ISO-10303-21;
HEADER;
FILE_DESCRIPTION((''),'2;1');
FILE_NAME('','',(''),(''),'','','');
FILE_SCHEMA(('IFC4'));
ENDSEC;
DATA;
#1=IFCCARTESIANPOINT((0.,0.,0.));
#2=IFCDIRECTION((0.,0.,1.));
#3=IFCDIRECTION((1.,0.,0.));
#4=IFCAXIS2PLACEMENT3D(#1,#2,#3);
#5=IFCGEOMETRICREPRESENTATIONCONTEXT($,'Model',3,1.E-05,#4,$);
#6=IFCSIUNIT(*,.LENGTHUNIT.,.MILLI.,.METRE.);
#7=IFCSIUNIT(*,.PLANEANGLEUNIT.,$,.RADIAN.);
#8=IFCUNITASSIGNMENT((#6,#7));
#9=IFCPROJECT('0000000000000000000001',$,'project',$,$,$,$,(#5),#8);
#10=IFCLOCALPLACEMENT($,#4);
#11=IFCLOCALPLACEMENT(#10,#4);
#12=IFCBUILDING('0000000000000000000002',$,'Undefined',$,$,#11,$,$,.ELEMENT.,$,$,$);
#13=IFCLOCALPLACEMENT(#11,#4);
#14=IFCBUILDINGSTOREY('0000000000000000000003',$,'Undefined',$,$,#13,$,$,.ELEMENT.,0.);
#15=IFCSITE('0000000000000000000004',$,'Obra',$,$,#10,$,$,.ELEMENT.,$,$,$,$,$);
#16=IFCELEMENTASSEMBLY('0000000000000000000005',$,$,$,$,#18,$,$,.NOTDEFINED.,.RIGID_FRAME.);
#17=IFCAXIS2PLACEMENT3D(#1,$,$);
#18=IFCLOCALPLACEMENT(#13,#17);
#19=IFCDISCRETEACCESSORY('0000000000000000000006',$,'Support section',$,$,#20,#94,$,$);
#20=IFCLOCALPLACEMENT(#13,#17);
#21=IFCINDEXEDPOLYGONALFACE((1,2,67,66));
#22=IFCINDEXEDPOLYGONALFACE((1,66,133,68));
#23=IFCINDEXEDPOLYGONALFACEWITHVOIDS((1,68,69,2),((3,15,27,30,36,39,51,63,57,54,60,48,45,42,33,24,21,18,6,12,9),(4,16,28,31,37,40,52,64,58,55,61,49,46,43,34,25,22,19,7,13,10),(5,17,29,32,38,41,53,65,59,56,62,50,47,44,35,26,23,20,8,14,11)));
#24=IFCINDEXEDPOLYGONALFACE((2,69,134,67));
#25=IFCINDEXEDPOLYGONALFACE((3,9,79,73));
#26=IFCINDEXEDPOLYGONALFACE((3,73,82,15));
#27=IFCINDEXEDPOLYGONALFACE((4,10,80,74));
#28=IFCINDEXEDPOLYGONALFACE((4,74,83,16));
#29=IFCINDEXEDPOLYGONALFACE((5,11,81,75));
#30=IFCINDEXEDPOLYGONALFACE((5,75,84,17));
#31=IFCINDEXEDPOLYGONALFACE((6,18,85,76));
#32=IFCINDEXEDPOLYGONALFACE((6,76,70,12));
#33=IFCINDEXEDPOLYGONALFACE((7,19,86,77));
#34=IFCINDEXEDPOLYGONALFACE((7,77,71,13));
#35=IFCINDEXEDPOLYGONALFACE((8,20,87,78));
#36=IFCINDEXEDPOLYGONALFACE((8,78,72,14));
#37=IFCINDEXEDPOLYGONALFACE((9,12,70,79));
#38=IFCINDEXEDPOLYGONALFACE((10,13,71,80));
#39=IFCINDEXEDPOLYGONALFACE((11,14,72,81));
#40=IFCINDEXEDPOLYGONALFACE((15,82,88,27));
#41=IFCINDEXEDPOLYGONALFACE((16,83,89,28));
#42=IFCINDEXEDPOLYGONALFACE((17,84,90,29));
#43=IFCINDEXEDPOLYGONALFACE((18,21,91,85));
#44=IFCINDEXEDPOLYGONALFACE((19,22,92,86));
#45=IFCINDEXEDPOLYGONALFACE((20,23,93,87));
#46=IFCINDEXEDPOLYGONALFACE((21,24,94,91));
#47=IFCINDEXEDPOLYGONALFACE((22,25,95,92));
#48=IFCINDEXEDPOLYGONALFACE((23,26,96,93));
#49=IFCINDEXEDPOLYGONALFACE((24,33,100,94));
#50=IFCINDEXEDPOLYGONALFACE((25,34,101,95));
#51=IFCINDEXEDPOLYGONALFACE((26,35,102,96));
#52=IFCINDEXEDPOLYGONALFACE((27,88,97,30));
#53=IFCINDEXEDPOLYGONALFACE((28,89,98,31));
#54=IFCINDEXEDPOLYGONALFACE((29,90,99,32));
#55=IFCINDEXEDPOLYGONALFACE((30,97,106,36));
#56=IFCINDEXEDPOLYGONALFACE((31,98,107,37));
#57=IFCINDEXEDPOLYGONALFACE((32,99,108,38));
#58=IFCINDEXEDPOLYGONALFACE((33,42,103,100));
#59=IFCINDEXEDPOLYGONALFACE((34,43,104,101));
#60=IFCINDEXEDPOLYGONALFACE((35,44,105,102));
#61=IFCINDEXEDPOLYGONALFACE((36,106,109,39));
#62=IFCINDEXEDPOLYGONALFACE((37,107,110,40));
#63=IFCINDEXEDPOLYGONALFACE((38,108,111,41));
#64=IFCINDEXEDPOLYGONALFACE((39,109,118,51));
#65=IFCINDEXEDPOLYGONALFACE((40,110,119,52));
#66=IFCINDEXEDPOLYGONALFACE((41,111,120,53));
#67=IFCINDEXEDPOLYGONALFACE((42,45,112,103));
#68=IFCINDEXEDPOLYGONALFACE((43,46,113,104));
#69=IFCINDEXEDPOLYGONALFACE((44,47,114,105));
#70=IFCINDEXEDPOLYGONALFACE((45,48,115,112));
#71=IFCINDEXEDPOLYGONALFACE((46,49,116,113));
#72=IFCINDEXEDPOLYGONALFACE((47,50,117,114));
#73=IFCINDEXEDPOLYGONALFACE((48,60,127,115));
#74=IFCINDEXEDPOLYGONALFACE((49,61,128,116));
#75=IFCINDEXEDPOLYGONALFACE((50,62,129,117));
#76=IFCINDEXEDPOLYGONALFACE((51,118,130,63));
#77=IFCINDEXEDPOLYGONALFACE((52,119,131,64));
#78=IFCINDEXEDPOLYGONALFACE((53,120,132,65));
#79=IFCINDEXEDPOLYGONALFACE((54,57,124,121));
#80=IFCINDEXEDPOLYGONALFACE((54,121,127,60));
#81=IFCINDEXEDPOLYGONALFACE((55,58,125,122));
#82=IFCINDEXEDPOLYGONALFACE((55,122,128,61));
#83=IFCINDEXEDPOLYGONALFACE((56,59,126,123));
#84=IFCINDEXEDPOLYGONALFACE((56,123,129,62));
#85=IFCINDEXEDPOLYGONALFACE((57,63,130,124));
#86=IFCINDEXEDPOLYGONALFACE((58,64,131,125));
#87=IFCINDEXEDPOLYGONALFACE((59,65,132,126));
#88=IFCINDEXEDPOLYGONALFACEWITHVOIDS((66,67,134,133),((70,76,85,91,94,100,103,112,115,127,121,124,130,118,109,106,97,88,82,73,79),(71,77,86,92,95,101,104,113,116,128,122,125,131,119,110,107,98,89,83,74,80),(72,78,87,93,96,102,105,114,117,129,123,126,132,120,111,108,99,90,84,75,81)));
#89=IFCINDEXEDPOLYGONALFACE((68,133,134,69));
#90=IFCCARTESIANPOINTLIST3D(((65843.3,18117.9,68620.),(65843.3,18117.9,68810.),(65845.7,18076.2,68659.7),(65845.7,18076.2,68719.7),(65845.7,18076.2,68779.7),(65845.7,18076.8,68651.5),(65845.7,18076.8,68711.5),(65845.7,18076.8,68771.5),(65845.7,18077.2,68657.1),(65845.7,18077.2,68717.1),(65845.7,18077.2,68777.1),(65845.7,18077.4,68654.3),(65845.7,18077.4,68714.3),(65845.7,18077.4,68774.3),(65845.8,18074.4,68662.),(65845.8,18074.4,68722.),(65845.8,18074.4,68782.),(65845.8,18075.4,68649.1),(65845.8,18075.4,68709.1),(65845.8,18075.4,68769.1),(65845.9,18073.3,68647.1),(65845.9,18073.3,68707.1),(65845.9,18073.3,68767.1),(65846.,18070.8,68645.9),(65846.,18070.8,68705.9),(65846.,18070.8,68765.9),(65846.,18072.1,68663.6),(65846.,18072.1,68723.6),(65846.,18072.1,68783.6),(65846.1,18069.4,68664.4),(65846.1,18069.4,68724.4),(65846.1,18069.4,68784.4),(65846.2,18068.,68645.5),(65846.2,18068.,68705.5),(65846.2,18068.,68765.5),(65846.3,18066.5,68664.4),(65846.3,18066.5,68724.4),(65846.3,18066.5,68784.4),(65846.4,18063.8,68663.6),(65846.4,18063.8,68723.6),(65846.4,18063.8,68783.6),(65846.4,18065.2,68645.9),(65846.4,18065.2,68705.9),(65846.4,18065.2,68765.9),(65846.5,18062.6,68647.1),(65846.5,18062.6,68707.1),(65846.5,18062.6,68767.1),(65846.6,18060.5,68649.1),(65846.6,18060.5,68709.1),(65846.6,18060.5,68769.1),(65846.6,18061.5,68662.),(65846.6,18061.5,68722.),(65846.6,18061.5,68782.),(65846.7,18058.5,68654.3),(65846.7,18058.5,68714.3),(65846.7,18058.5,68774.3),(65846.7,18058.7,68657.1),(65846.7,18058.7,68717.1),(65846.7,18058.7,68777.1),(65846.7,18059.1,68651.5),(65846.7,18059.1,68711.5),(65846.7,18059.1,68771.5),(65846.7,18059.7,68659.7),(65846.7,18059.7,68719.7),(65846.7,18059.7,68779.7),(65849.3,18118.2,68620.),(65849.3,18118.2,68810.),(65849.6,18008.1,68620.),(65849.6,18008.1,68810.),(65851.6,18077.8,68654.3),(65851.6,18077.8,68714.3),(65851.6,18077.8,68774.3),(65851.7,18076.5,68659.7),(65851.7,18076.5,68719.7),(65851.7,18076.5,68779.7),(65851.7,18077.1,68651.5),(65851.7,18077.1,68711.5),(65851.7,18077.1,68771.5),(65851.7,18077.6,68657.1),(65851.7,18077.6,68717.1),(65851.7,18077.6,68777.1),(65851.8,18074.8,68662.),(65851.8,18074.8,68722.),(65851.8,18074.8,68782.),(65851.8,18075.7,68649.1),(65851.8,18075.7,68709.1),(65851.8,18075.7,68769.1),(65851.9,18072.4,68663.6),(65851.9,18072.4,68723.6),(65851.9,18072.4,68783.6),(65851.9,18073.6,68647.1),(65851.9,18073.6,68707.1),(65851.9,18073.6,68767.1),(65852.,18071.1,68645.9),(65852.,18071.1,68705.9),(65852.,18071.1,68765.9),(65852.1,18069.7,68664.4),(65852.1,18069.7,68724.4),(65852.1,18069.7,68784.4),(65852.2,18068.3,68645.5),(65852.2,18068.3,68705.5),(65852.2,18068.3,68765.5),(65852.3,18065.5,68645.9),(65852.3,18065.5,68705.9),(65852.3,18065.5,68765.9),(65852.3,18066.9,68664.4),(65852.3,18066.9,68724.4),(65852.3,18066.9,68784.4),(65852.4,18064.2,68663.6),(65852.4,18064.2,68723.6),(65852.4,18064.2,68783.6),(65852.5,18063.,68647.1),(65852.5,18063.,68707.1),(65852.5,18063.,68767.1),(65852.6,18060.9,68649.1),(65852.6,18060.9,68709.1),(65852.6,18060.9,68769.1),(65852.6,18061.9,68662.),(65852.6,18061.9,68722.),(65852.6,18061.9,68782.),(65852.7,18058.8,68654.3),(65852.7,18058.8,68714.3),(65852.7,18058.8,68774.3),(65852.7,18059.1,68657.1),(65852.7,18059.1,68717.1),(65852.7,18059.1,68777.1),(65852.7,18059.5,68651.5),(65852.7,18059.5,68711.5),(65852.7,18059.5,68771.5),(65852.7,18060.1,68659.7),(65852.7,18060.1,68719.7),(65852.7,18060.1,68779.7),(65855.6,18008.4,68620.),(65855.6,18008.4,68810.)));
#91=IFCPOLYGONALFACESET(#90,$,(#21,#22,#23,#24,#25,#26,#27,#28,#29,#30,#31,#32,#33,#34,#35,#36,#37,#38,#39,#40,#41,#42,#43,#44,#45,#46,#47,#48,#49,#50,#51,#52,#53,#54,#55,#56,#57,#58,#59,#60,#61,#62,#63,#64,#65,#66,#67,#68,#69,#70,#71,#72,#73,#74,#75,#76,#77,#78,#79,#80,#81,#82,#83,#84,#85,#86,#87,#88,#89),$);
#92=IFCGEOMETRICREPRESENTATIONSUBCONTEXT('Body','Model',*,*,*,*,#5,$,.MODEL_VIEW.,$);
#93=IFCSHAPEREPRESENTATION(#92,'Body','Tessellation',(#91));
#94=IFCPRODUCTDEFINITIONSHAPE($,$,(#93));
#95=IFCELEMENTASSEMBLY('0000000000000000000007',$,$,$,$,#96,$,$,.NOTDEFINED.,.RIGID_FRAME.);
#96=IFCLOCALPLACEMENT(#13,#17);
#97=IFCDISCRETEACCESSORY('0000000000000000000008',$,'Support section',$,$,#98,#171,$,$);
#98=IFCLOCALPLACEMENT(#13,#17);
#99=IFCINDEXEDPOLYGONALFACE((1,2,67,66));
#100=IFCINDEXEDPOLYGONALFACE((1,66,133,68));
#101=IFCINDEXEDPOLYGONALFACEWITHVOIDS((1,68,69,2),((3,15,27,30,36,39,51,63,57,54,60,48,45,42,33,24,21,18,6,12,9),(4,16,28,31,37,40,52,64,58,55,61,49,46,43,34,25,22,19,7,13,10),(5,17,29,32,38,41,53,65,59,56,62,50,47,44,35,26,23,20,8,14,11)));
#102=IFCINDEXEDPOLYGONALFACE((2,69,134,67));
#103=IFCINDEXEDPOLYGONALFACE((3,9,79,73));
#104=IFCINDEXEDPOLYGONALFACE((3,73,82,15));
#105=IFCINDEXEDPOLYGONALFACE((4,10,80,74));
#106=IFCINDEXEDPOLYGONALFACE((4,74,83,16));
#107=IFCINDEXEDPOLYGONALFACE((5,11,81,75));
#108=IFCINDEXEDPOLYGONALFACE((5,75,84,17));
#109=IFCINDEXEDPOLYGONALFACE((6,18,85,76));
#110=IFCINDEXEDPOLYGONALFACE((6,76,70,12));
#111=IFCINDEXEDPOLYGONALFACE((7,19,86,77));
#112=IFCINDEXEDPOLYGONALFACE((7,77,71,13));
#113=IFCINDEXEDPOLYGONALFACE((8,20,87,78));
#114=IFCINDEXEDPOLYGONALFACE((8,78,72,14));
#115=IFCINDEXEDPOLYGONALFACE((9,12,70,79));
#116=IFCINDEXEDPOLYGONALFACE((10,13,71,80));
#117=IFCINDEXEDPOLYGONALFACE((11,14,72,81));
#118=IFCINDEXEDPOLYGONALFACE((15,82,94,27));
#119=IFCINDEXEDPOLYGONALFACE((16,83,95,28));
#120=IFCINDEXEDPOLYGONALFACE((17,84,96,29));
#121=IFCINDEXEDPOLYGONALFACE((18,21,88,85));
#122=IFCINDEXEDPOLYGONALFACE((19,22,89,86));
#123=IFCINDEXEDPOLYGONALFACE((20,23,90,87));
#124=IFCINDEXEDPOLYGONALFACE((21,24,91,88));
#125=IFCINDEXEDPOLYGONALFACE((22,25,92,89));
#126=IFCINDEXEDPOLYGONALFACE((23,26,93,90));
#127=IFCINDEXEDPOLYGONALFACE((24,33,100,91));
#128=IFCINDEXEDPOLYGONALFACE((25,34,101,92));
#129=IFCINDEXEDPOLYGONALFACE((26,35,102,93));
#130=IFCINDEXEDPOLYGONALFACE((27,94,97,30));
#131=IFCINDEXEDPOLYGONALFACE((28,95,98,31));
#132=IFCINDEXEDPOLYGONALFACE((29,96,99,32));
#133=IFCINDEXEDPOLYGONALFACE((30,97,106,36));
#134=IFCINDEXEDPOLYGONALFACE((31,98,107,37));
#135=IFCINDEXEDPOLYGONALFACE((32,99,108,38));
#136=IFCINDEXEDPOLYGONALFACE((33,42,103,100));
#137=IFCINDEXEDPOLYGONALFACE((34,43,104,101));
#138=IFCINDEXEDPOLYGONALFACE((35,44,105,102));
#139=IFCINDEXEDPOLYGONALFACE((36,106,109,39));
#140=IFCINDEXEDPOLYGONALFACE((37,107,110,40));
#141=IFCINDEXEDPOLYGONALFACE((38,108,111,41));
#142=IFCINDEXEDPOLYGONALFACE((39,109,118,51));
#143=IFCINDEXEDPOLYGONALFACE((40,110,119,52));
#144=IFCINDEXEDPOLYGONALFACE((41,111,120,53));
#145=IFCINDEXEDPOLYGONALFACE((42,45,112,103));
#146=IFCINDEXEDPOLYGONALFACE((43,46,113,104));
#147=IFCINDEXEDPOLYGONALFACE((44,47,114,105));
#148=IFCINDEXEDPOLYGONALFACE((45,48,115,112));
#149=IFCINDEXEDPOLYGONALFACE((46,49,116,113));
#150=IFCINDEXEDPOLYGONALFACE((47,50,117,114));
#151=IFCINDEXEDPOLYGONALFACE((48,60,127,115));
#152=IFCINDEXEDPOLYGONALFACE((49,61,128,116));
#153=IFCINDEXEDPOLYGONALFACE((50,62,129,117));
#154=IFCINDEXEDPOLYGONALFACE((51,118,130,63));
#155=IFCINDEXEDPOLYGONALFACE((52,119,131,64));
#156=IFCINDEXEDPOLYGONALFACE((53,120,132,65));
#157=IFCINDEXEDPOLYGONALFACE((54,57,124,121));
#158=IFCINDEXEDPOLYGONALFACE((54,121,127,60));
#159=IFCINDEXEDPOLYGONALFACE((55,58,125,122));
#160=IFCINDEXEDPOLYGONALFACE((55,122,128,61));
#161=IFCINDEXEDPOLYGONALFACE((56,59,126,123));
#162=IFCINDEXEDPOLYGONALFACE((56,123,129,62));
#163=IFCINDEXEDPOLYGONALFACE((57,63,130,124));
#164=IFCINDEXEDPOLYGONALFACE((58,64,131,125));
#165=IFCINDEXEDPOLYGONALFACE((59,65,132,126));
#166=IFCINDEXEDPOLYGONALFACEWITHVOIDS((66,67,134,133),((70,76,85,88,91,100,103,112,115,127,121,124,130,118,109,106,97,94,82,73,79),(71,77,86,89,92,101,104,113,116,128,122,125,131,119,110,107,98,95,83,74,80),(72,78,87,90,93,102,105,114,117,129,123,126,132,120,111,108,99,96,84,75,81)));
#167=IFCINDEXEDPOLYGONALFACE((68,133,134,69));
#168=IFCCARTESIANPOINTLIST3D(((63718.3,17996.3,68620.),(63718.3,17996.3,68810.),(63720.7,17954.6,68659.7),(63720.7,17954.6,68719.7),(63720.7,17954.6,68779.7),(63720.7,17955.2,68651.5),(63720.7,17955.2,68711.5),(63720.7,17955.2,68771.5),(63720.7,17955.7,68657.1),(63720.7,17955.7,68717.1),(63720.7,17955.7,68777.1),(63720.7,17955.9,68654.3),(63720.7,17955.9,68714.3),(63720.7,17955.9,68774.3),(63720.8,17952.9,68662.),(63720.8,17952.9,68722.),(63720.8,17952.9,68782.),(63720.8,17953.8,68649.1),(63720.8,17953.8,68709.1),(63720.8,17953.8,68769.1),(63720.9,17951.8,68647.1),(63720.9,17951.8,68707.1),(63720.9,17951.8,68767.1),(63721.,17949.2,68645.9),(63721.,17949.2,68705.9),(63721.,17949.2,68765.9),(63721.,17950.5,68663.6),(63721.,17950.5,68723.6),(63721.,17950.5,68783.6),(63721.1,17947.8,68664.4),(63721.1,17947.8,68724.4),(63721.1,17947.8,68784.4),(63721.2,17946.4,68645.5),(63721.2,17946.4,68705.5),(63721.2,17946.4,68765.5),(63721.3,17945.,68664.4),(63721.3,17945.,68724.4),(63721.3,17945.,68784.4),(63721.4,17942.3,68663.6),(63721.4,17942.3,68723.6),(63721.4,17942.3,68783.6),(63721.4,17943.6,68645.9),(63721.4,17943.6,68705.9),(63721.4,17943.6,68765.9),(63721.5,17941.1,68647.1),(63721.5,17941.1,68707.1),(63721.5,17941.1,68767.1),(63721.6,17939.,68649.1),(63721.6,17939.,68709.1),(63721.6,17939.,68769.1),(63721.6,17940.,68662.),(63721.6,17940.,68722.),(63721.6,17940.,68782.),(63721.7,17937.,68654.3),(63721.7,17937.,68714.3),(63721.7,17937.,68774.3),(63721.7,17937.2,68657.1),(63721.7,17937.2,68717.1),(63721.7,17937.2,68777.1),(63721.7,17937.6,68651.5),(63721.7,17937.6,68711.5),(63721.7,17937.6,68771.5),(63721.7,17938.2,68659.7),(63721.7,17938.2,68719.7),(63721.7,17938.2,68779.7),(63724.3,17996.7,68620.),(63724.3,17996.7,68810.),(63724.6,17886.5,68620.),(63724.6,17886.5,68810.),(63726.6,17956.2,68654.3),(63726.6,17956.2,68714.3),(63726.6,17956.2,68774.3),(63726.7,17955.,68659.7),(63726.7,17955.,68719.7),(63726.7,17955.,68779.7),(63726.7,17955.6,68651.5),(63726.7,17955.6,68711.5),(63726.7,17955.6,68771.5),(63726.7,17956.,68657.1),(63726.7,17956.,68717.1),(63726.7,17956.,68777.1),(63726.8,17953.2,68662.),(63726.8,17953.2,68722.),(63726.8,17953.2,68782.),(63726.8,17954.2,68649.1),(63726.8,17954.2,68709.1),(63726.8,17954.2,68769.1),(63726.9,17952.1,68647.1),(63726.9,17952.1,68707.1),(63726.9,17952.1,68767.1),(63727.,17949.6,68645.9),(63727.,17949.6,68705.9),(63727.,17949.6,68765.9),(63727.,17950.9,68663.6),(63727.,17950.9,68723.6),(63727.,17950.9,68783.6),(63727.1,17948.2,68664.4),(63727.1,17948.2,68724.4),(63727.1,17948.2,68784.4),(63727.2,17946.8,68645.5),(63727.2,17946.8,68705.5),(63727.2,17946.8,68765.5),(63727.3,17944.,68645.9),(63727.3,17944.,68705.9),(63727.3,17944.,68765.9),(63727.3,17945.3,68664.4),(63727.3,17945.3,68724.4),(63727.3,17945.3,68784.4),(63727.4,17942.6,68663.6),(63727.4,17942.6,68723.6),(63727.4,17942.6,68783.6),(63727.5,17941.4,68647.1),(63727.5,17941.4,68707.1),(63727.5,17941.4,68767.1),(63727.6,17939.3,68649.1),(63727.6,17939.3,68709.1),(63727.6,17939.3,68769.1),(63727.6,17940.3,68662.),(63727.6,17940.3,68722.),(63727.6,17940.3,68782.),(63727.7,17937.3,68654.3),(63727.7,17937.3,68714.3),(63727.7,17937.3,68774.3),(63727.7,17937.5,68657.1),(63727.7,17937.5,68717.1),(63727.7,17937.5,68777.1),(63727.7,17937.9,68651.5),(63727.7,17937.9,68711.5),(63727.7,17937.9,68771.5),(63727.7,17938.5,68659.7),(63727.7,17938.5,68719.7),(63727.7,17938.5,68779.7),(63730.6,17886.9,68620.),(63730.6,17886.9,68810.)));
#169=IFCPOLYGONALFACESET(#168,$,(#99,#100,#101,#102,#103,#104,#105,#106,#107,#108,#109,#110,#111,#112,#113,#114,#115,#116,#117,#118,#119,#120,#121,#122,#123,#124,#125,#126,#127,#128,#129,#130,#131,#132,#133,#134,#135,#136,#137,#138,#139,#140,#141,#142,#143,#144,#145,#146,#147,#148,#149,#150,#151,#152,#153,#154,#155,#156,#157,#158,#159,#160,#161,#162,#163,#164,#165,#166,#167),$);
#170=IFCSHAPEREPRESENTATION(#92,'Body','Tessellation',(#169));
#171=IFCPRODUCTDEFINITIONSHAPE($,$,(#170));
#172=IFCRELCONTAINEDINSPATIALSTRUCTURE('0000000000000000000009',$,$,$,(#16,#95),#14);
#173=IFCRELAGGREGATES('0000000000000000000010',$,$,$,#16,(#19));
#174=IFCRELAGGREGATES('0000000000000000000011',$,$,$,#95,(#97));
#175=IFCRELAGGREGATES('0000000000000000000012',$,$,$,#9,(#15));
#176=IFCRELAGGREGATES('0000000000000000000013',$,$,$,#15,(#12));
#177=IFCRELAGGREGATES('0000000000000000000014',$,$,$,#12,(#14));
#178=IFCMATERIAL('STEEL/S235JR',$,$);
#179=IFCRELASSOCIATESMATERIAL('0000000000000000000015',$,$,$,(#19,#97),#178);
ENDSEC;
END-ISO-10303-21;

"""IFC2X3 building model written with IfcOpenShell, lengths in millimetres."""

from ifc_helpers import new_model, si_unit, frame, origin_with_axes, origin_2d_with_axis, place, context, subcontext, project, spatial, rectangle, circle, extrude, source, transform, mapped, material, element, aggregate, save


model = new_model("IFC2X3")

# Units and contexts
model_context = context("Model", 3, precision=1e-05, world=origin_with_axes())
body_context = subcontext(model_context, "Body", "Model", "MODEL_VIEW")
ifc_project = project(units=[si_unit("LENGTHUNIT", "METRE", prefix="MILLI"), si_unit("PLANEANGLEUNIT", "RADIAN")], contexts=[model_context])

# Site, building, storey
site_placement = place(None, origin_with_axes())
site = spatial("IfcSite", under=ifc_project, at=site_placement, Name="Obra", CompositionType="ELEMENT")
building_placement = place(site_placement, origin_with_axes())
building = spatial("IfcBuilding", under=site, at=building_placement, Name="Undefined", CompositionType="ELEMENT")
storey_placement = place(building_placement, origin_with_axes())
storey = spatial("IfcBuildingStorey", under=building, at=storey_placement, Name="Undefined", CompositionType="ELEMENT", Elevation=0.0)

# Element assembly
assembly_1_placement = place(storey_placement, origin_with_axes())
assembly_1 = element("IfcElementAssembly", 1, at=assembly_1_placement, inside=storey, AssemblyPlace="NOTDEFINED", PredefinedType="RIGID_FRAME")
ifc_material = material(Name="STEEL/S235JR")

# Discrete accessory, opening
discrete_accessory_1_placement = place(assembly_1_placement, frame((65849.5, 18063.1, 68620.0), z_axis=(0.0, 0.0, 1.0), x_axis=(0.057107, -0.998368, 0.0)))
discrete_accessory_1 = element("IfcDiscreteAccessory", 2, at=discrete_accessory_1_placement, material=ifc_material, Name="Support section", context=body_context, shape_type="SweptSolid", body=[
    extrude(rectangle(XDim=6.0, YDim=110.0, at=origin_2d_with_axis()), frame((0.0, 0.0, 190.0), z_axis=(0.0, 0.0, -1.0), x_axis=(0.0, 1.0, 0.0)), (0.0, 0.0, 1.0), 190.0),
])
shared_shape_1 = source(origin_with_axes(), body_context, "Body", "SweptSolid", [
    extrude(circle(Radius=9.5, at=origin_2d_with_axis()), frame((0.0, -9.2, 0.0), z_axis=(0.0, 1.0, 0.0), x_axis=(1.0, 0.0, 0.0)), (0.0, 0.0, 1.0), 6.2),
])
opening_1_placement = place(assembly_1_placement, frame((65846.0, 18017.9, 68835.0), z_axis=(-0.057107, 0.998368, 0.0), x_axis=(0.0, 0.0, -1.0)))
element("IfcOpeningElement", 3, at=opening_1_placement, cuts=discrete_accessory_1, ObjectType="Opening", context=body_context, shape_type="MappedRepresentation", body=[
    mapped(shared_shape_1, transform((60.0, 0.0, 50.0))),
    mapped(shared_shape_1, transform((120.0, 0.0, 50.0))),
    mapped(shared_shape_1, transform((180.0, 0.0, 50.0))),
])
aggregate(assembly_1, [discrete_accessory_1])

# Element assembly, discrete accessory, opening
assembly_2_placement = place(storey_placement, origin_with_axes())
assembly_2 = element("IfcElementAssembly", 4, at=assembly_2_placement, inside=storey, AssemblyPlace="NOTDEFINED", PredefinedType="RIGID_FRAME")
discrete_accessory_2_placement = place(assembly_2_placement, frame((63724.5, 17941.6, 68620.0), z_axis=(0.0, 0.0, 1.0), x_axis=(0.057107, -0.998368, 0.0)))
discrete_accessory_2 = element("IfcDiscreteAccessory", 5, at=discrete_accessory_2_placement, material=ifc_material, Name="Support section", context=body_context, shape_type="SweptSolid", body=[
    extrude(rectangle(XDim=6.0, YDim=110.0, at=origin_2d_with_axis()), frame((0.0, 0.0, 190.0), z_axis=(0.0, 0.0, -1.0), x_axis=(0.0, 1.0, 0.0)), (0.0, 0.0, 1.0), 190.0),
])
opening_2_placement = place(assembly_2_placement, frame((63721.0, 17896.3, 68835.0), z_axis=(-0.057107, 0.998368, 0.0), x_axis=(0.0, 0.0, -1.0)))
element("IfcOpeningElement", 6, at=opening_2_placement, cuts=discrete_accessory_2, ObjectType="Opening", context=body_context, shape_type="MappedRepresentation", body=[
    mapped(shared_shape_1, transform((60.0, 0.0, 50.0))),
    mapped(shared_shape_1, transform((120.0, 0.0, 50.0))),
    mapped(shared_shape_1, transform((180.0, 0.0, 50.0))),
])
aggregate(assembly_2, [discrete_accessory_2])

save(model, "model.ifc")
